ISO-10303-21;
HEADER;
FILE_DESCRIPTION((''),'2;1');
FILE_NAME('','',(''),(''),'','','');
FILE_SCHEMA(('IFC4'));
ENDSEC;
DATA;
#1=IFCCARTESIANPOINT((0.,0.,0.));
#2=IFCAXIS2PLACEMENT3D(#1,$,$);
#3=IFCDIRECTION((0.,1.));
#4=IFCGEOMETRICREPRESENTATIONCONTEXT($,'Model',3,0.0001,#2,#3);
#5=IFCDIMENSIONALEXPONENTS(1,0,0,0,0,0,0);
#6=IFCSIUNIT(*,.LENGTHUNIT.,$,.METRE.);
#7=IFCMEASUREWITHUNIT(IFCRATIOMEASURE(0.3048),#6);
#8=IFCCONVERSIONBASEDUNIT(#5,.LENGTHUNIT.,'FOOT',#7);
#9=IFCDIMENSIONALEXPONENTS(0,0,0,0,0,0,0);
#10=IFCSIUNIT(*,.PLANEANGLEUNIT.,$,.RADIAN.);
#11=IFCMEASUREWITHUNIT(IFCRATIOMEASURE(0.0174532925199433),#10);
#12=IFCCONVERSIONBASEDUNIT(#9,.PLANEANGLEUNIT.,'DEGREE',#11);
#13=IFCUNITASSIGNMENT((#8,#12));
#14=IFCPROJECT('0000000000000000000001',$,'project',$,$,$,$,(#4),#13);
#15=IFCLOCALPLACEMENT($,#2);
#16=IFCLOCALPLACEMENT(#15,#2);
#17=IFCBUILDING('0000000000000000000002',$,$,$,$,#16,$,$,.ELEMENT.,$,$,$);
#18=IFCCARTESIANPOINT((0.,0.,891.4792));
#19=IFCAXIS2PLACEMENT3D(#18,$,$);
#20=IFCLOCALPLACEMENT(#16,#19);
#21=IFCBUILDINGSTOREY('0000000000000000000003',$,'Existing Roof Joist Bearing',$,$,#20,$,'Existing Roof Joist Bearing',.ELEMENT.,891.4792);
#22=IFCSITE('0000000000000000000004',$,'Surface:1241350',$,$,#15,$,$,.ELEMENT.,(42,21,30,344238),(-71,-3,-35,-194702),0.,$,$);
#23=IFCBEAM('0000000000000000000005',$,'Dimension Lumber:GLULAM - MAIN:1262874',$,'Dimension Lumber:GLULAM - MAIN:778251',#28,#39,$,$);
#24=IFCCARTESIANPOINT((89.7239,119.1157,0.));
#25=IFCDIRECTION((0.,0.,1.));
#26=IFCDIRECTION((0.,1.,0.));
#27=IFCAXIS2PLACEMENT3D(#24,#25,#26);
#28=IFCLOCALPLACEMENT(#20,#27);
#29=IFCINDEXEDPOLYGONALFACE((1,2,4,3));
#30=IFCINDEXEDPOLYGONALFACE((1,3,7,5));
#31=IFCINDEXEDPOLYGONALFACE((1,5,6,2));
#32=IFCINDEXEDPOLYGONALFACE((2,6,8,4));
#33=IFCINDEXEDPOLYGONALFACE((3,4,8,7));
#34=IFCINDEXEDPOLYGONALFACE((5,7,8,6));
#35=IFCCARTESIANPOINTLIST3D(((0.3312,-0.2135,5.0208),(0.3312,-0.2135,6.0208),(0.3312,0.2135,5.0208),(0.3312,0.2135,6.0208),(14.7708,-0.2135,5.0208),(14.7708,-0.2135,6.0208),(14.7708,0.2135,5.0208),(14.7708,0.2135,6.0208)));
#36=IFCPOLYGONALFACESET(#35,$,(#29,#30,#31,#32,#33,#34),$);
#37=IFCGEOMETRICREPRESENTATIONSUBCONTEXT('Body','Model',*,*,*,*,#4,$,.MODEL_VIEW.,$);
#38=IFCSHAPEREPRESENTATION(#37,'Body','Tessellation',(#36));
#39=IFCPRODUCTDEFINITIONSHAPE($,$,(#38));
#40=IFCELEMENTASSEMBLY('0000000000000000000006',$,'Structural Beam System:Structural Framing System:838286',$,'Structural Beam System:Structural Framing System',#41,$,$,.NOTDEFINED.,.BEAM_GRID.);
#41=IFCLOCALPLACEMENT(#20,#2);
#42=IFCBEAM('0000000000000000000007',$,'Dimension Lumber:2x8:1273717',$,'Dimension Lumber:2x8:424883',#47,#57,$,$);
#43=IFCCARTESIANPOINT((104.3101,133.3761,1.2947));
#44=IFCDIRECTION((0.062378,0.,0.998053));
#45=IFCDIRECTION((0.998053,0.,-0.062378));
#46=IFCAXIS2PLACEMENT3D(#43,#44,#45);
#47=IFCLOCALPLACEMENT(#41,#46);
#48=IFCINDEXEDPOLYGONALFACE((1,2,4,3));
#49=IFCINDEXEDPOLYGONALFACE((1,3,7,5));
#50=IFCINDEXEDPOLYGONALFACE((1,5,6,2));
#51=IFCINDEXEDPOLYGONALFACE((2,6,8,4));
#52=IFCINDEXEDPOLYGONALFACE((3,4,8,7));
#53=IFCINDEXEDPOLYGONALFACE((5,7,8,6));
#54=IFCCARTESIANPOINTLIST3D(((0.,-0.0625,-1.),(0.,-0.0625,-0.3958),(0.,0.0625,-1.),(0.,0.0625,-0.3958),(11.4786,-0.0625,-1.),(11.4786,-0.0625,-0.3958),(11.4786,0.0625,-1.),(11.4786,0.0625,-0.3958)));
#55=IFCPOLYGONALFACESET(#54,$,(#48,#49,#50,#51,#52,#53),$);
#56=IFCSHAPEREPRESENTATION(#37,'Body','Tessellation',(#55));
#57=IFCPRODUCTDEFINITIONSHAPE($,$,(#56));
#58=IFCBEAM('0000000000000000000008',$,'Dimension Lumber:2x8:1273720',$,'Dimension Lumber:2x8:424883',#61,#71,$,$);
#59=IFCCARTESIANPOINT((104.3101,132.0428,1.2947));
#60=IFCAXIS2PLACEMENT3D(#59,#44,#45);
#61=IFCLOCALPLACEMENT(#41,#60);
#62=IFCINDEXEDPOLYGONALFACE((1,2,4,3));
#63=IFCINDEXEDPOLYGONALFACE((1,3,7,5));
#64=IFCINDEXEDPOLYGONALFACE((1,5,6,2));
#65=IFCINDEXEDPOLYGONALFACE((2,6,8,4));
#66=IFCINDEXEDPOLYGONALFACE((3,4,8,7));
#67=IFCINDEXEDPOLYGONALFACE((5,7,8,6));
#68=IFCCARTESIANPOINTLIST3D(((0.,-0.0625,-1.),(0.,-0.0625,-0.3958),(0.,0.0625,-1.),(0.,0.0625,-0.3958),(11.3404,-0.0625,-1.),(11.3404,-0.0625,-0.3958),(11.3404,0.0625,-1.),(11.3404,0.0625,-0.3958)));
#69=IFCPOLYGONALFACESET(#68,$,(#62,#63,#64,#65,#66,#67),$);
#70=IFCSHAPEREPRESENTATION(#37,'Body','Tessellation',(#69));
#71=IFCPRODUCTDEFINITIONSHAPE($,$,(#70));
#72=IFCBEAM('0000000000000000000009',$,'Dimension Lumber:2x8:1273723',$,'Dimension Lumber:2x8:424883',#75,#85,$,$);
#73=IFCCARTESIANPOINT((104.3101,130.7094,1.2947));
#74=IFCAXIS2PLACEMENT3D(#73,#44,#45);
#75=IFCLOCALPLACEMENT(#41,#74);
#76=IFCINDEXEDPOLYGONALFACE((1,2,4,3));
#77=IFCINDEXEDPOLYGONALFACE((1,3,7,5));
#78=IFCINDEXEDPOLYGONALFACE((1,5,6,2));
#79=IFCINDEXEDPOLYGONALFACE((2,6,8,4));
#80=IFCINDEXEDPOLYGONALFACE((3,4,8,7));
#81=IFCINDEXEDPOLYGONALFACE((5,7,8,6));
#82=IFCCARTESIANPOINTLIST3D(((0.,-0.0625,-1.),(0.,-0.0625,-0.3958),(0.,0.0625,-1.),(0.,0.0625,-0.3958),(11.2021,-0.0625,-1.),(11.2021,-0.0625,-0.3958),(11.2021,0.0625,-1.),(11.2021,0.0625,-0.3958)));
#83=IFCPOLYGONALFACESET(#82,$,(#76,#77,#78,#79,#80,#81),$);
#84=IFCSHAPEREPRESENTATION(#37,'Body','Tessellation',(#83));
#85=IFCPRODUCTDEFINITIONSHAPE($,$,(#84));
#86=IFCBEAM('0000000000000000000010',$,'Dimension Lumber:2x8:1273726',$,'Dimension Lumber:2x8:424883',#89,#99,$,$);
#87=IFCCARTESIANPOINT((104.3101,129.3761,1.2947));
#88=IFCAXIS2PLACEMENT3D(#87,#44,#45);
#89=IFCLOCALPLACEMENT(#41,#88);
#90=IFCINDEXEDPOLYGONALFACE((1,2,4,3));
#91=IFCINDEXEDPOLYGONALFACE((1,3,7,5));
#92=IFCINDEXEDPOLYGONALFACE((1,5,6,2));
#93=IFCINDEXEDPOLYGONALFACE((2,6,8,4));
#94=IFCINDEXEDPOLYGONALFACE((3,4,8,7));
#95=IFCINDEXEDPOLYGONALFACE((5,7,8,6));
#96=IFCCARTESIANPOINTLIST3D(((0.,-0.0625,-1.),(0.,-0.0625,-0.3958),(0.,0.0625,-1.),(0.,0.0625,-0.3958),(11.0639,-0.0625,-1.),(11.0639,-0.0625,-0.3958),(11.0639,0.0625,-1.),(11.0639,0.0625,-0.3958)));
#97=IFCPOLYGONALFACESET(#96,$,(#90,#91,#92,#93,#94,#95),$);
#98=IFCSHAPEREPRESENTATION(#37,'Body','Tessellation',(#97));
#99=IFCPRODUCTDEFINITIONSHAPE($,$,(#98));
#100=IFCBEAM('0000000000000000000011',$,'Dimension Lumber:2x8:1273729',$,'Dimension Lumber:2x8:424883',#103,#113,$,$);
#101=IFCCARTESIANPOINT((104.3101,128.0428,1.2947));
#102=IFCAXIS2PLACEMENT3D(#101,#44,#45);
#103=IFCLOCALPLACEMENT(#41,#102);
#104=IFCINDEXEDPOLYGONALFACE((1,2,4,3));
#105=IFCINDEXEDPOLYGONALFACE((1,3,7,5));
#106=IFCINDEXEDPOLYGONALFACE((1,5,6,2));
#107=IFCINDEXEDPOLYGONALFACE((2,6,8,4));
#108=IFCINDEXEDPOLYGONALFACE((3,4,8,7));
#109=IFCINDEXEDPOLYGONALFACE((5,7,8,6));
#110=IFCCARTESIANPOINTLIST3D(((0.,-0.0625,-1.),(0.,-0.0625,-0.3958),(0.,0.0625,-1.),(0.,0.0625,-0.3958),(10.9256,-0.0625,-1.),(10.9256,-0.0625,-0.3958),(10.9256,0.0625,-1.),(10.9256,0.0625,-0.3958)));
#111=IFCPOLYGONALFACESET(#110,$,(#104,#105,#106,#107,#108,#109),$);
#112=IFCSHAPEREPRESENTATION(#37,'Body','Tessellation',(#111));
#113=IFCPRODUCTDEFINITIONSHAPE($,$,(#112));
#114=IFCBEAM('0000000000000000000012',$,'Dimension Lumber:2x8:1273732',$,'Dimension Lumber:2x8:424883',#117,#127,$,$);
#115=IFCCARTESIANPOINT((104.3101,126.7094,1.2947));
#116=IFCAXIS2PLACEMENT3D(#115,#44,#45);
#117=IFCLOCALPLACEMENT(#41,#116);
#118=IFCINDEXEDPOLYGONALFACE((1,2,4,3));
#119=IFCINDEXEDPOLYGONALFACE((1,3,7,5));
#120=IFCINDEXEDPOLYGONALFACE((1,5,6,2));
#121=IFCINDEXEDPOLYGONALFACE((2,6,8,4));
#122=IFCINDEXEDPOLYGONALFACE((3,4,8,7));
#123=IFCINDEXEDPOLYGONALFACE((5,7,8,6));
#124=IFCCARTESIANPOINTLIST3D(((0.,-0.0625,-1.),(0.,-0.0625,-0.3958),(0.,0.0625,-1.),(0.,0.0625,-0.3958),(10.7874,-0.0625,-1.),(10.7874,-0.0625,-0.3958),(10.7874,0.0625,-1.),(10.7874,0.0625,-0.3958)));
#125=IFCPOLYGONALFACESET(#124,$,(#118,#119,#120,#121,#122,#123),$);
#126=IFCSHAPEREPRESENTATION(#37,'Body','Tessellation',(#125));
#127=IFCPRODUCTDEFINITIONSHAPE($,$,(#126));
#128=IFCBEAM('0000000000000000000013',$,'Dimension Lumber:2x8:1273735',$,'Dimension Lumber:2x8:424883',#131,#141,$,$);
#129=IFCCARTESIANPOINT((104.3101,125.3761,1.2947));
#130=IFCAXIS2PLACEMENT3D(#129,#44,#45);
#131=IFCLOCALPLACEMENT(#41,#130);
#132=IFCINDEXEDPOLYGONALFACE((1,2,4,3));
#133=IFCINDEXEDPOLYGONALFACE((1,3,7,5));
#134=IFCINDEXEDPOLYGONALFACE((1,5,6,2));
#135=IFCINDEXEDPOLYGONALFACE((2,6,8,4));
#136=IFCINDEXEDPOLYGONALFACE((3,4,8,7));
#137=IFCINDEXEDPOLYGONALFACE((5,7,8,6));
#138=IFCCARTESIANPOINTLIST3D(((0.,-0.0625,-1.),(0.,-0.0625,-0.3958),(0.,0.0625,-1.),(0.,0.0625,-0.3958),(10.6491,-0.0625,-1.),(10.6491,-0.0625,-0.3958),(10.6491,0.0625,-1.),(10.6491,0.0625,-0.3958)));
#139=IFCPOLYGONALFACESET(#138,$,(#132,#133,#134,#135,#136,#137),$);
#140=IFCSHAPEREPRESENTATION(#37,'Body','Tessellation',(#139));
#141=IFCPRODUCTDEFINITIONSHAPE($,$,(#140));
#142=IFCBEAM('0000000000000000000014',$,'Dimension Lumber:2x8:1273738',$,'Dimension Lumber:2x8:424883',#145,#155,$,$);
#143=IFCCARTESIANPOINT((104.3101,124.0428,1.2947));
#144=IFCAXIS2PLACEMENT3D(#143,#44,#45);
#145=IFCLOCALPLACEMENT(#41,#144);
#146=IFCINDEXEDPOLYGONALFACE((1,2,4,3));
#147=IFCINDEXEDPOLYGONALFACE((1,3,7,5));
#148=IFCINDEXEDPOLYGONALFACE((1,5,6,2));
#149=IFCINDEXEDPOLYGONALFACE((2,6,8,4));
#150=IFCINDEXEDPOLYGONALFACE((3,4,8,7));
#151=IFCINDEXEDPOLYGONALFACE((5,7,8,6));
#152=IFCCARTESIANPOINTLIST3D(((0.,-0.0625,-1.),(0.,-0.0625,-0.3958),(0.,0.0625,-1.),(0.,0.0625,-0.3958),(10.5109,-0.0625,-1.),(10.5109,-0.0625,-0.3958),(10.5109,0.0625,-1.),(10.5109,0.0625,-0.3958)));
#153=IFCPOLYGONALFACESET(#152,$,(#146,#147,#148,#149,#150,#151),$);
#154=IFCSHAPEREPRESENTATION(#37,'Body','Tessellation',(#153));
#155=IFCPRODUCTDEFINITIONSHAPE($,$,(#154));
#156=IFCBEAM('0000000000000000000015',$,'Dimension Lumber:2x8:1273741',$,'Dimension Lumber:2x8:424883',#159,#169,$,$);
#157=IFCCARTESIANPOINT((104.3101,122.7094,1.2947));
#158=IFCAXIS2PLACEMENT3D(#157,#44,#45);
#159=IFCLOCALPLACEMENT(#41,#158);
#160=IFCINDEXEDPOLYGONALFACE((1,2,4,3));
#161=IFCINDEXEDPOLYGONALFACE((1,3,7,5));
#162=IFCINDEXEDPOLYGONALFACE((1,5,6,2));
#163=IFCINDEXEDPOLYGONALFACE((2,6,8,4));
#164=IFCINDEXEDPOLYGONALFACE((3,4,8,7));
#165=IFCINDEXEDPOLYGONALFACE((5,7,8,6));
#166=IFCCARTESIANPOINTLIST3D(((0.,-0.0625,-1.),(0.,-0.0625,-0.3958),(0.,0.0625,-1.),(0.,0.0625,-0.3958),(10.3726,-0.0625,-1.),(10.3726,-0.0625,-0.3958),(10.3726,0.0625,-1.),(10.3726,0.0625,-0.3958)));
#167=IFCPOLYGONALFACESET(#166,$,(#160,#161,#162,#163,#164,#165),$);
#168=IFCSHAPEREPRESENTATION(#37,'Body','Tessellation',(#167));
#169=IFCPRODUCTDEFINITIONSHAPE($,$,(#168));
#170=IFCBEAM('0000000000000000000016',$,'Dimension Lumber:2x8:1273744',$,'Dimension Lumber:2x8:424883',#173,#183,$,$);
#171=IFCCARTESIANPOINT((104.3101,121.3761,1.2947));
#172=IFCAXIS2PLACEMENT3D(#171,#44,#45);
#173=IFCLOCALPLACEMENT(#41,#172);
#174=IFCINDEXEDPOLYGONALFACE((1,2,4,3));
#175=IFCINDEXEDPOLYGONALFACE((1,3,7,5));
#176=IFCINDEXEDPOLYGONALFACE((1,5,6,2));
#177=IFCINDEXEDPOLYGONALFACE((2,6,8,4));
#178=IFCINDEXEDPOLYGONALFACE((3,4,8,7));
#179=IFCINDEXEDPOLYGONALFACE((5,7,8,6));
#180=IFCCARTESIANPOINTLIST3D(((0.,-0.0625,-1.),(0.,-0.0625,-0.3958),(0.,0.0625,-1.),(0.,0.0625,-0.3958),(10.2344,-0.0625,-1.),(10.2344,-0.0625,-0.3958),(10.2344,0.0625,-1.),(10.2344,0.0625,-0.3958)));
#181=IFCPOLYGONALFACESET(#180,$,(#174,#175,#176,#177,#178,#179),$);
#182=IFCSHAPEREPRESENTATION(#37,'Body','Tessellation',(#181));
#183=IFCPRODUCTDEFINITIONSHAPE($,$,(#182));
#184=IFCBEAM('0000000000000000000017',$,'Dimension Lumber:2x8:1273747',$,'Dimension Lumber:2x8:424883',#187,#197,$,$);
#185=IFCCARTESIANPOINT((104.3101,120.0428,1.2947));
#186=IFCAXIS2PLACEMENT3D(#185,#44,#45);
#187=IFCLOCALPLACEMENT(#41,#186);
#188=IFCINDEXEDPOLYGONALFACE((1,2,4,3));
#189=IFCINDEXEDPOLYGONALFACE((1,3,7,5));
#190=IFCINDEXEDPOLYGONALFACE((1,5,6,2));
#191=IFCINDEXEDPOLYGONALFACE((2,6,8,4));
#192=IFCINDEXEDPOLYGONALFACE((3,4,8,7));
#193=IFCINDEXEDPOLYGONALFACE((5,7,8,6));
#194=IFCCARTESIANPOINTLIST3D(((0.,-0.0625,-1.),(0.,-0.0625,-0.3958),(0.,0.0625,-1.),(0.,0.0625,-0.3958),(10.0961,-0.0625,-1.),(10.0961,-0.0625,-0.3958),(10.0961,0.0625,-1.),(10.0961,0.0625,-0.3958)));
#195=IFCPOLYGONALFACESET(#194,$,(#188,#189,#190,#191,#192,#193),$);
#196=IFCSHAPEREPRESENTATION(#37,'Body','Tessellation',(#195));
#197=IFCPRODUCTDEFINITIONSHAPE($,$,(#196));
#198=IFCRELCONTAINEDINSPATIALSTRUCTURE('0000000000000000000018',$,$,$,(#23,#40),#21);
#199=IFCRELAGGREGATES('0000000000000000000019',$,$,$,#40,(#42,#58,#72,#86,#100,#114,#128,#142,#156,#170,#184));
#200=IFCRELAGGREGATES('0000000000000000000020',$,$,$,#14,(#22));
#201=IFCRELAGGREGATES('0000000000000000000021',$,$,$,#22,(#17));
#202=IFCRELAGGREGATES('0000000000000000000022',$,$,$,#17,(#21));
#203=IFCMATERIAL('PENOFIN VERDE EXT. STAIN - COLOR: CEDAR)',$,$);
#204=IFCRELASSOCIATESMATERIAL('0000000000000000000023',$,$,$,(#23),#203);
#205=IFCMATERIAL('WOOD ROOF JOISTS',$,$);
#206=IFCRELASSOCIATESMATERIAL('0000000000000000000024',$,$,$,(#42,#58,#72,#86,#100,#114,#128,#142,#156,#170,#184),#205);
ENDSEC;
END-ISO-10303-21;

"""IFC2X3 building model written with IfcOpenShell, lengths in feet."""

from ifc_helpers import new_model, entity, si_unit, converted_unit, direction, frame, frame_2d, origin, place, context, subcontext, project, spatial, rectangle, extrude, material, element, aggregate, save


model = new_model("IFC2X3")

# Units and contexts
model_context = context("Model", 3, precision=0.0001, world=origin(), true_north=direction((0.0, 1.0)))
body_context = subcontext(model_context, "Body", "Model", "MODEL_VIEW")
ifc_project = project(units=[converted_unit("LENGTHUNIT", "FOOT", entity("IfcRatioMeasure", 0.3048), si_unit("LENGTHUNIT", "METRE"), dimensions=[1, 0, 0, 0, 0, 0, 0]), converted_unit("PLANEANGLEUNIT", "DEGREE", entity("IfcRatioMeasure", 0.0174532925199433), si_unit("PLANEANGLEUNIT", "RADIAN"), dimensions=[0, 0, 0, 0, 0, 0, 0])], contexts=[model_context])

# Site, building, storey
site_placement = place(None, origin())
site = spatial("IfcSite", under=ifc_project, at=site_placement, Name="Surface:1241350", CompositionType="ELEMENT", RefLatitude=(42, 21, 30, 344238), RefLongitude=(-71, -3, -35, -194702), RefElevation=0.0)
building_placement = place(site_placement, origin())
building = spatial("IfcBuilding", under=site, at=building_placement, CompositionType="ELEMENT")
storey_placement = place(building_placement, frame((0.0, 0.0, 891.4792)))
storey = spatial("IfcBuildingStorey", under=building, at=storey_placement, Name="Existing Roof Joist Bearing", LongName="Existing Roof Joist Bearing", CompositionType="ELEMENT", Elevation=891.4792)

# Beam
ifc_material_1 = material(Name="PENOFIN VERDE EXT. STAIN - COLOR: CEDAR)")
beam_1_placement = place(storey_placement, frame((89.7239, 119.1157, 0.0), z_axis=(0.0, 0.0, 1.0), x_axis=(0.0, 1.0, 0.0)))
element("IfcBeam", 1, at=beam_1_placement, inside=storey, material=ifc_material_1, Name="Dimension Lumber:GLULAM - MAIN:1262874", ObjectType="Dimension Lumber:GLULAM - MAIN:778251", context=body_context, shape_type="SweptSolid", body=[
    extrude(rectangle(XDim=1.0, YDim=0.4271, at=frame_2d((0.0, 0.0), x_axis=(1.0, 0.0))), frame((0.3312, 0.0, 5.5208), z_axis=(1.0, 0.0, 0.0), x_axis=(0.0, 0.0, -1.0)), (0.0, 0.0, 1.0), 14.4396),
])

# Element assembly, beams
assembly_1_placement = place(storey_placement, origin())
assembly_1 = element("IfcElementAssembly", 2, at=assembly_1_placement, inside=storey, Name="Structural Beam System:Structural Framing System:838286", ObjectType="Structural Beam System:Structural Framing System", AssemblyPlace="NOTDEFINED", PredefinedType="BEAM_GRID")
ifc_material_2 = material(Name="WOOD ROOF JOISTS")
beam_2_placement = place(assembly_1_placement, frame((104.3101, 133.3761, 1.2947), z_axis=(0.062378, 0.0, 0.998053), x_axis=(0.998053, 0.0, -0.062378)))
beam_2 = element("IfcBeam", 3, at=beam_2_placement, material=ifc_material_2, Name="Dimension Lumber:2x8:1273717", ObjectType="Dimension Lumber:2x8:424883", context=body_context, shape_type="SweptSolid", body=[
    extrude(rectangle(XDim=0.6042, YDim=0.125, at=frame_2d((0.0, 0.0), x_axis=(1.0, 0.0))), frame((0.0, 0.0, -0.6979), z_axis=(1.0, 0.0, 0.0), x_axis=(0.0, 0.0, -1.0)), (0.0, 0.0, 1.0), 11.4786),
])
beam_3_placement = place(assembly_1_placement, frame((104.3101, 132.0428, 1.2947), z_axis=(0.062378, 0.0, 0.998053), x_axis=(0.998053, 0.0, -0.062378)))
beam_3 = element("IfcBeam", 4, at=beam_3_placement, material=ifc_material_2, Name="Dimension Lumber:2x8:1273720", ObjectType="Dimension Lumber:2x8:424883", context=body_context, shape_type="SweptSolid", body=[
    extrude(rectangle(XDim=0.6042, YDim=0.125, at=frame_2d((0.0, 0.0), x_axis=(1.0, 0.0))), frame((0.0, 0.0, -0.6979), z_axis=(1.0, 0.0, 0.0), x_axis=(0.0, 0.0, -1.0)), (0.0, 0.0, 1.0), 11.3404),
])
beam_4_placement = place(assembly_1_placement, frame((104.3101, 130.7094, 1.2947), z_axis=(0.062378, 0.0, 0.998053), x_axis=(0.998053, 0.0, -0.062378)))
beam_4 = element("IfcBeam", 5, at=beam_4_placement, material=ifc_material_2, Name="Dimension Lumber:2x8:1273723", ObjectType="Dimension Lumber:2x8:424883", context=body_context, shape_type="SweptSolid", body=[
    extrude(rectangle(XDim=0.6042, YDim=0.125, at=frame_2d((0.0, 0.0), x_axis=(1.0, 0.0))), frame((0.0, 0.0, -0.6979), z_axis=(1.0, 0.0, 0.0), x_axis=(0.0, 0.0, -1.0)), (0.0, 0.0, 1.0), 11.2021),
])
beam_5_placement = place(assembly_1_placement, frame((104.3101, 129.3761, 1.2947), z_axis=(0.062378, 0.0, 0.998053), x_axis=(0.998053, 0.0, -0.062378)))
beam_5 = element("IfcBeam", 6, at=beam_5_placement, material=ifc_material_2, Name="Dimension Lumber:2x8:1273726", ObjectType="Dimension Lumber:2x8:424883", context=body_context, shape_type="SweptSolid", body=[
    extrude(rectangle(XDim=0.6042, YDim=0.125, at=frame_2d((0.0, 0.0), x_axis=(1.0, 0.0))), frame((0.0, 0.0, -0.6979), z_axis=(1.0, 0.0, 0.0), x_axis=(0.0, 0.0, -1.0)), (0.0, 0.0, 1.0), 11.0639),
])
beam_6_placement = place(assembly_1_placement, frame((104.3101, 128.0428, 1.2947), z_axis=(0.062378, 0.0, 0.998053), x_axis=(0.998053, 0.0, -0.062378)))
beam_6 = element("IfcBeam", 7, at=beam_6_placement, material=ifc_material_2, Name="Dimension Lumber:2x8:1273729", ObjectType="Dimension Lumber:2x8:424883", context=body_context, shape_type="SweptSolid", body=[
    extrude(rectangle(XDim=0.6042, YDim=0.125, at=frame_2d((0.0, 0.0), x_axis=(1.0, 0.0))), frame((0.0, 0.0, -0.6979), z_axis=(1.0, 0.0, 0.0), x_axis=(0.0, 0.0, -1.0)), (0.0, 0.0, 1.0), 10.9256),
])
beam_7_placement = place(assembly_1_placement, frame((104.3101, 126.7094, 1.2947), z_axis=(0.062378, 0.0, 0.998053), x_axis=(0.998053, 0.0, -0.062378)))
beam_7 = element("IfcBeam", 8, at=beam_7_placement, material=ifc_material_2, Name="Dimension Lumber:2x8:1273732", ObjectType="Dimension Lumber:2x8:424883", context=body_context, shape_type="SweptSolid", body=[
    extrude(rectangle(XDim=0.6042, YDim=0.125, at=frame_2d((0.0, 0.0), x_axis=(1.0, 0.0))), frame((0.0, 0.0, -0.6979), z_axis=(1.0, 0.0, 0.0), x_axis=(0.0, 0.0, -1.0)), (0.0, 0.0, 1.0), 10.7874),
])
beam_8_placement = place(assembly_1_placement, frame((104.3101, 125.3761, 1.2947), z_axis=(0.062378, 0.0, 0.998053), x_axis=(0.998053, 0.0, -0.062378)))
beam_8 = element("IfcBeam", 9, at=beam_8_placement, material=ifc_material_2, Name="Dimension Lumber:2x8:1273735", ObjectType="Dimension Lumber:2x8:424883", context=body_context, shape_type="SweptSolid", body=[
    extrude(rectangle(XDim=0.6042, YDim=0.125, at=frame_2d((0.0, 0.0), x_axis=(1.0, 0.0))), frame((0.0, 0.0, -0.6979), z_axis=(1.0, 0.0, 0.0), x_axis=(0.0, 0.0, -1.0)), (0.0, 0.0, 1.0), 10.6491),
])
beam_9_placement = place(assembly_1_placement, frame((104.3101, 124.0428, 1.2947), z_axis=(0.062378, 0.0, 0.998053), x_axis=(0.998053, 0.0, -0.062378)))
beam_9 = element("IfcBeam", 10, at=beam_9_placement, material=ifc_material_2, Name="Dimension Lumber:2x8:1273738", ObjectType="Dimension Lumber:2x8:424883", context=body_context, shape_type="SweptSolid", body=[
    extrude(rectangle(XDim=0.6042, YDim=0.125, at=frame_2d((0.0, 0.0), x_axis=(1.0, 0.0))), frame((0.0, 0.0, -0.6979), z_axis=(1.0, 0.0, 0.0), x_axis=(0.0, 0.0, -1.0)), (0.0, 0.0, 1.0), 10.5109),
])
beam_10_placement = place(assembly_1_placement, frame((104.3101, 122.7094, 1.2947), z_axis=(0.062378, 0.0, 0.998053), x_axis=(0.998053, 0.0, -0.062378)))
beam_10 = element("IfcBeam", 11, at=beam_10_placement, material=ifc_material_2, Name="Dimension Lumber:2x8:1273741", ObjectType="Dimension Lumber:2x8:424883", context=body_context, shape_type="SweptSolid", body=[
    extrude(rectangle(XDim=0.6042, YDim=0.125, at=frame_2d((0.0, 0.0), x_axis=(1.0, 0.0))), frame((0.0, 0.0, -0.6979), z_axis=(1.0, 0.0, 0.0), x_axis=(0.0, 0.0, -1.0)), (0.0, 0.0, 1.0), 10.3726),
])
beam_11_placement = place(assembly_1_placement, frame((104.3101, 121.3761, 1.2947), z_axis=(0.062378, 0.0, 0.998053), x_axis=(0.998053, 0.0, -0.062378)))
beam_11 = element("IfcBeam", 12, at=beam_11_placement, material=ifc_material_2, Name="Dimension Lumber:2x8:1273744", ObjectType="Dimension Lumber:2x8:424883", context=body_context, shape_type="SweptSolid", body=[
    extrude(rectangle(XDim=0.6042, YDim=0.125, at=frame_2d((0.0, 0.0), x_axis=(1.0, 0.0))), frame((0.0, 0.0, -0.6979), z_axis=(1.0, 0.0, 0.0), x_axis=(0.0, 0.0, -1.0)), (0.0, 0.0, 1.0), 10.2344),
])
beam_12_placement = place(assembly_1_placement, frame((104.3101, 120.0428, 1.2947), z_axis=(0.062378, 0.0, 0.998053), x_axis=(0.998053, 0.0, -0.062378)))
beam_12 = element("IfcBeam", 13, at=beam_12_placement, material=ifc_material_2, Name="Dimension Lumber:2x8:1273747", ObjectType="Dimension Lumber:2x8:424883", context=body_context, shape_type="SweptSolid", body=[
    extrude(rectangle(XDim=0.6042, YDim=0.125, at=frame_2d((0.0, 0.0), x_axis=(1.0, 0.0))), frame((0.0, 0.0, -0.6979), z_axis=(1.0, 0.0, 0.0), x_axis=(0.0, 0.0, -1.0)), (0.0, 0.0, 1.0), 10.0961),
])
aggregate(assembly_1, [beam_2, beam_3, beam_4, beam_5, beam_6, beam_7, beam_8, beam_9, beam_10, beam_11, beam_12])

save(model, "model.ifc")
